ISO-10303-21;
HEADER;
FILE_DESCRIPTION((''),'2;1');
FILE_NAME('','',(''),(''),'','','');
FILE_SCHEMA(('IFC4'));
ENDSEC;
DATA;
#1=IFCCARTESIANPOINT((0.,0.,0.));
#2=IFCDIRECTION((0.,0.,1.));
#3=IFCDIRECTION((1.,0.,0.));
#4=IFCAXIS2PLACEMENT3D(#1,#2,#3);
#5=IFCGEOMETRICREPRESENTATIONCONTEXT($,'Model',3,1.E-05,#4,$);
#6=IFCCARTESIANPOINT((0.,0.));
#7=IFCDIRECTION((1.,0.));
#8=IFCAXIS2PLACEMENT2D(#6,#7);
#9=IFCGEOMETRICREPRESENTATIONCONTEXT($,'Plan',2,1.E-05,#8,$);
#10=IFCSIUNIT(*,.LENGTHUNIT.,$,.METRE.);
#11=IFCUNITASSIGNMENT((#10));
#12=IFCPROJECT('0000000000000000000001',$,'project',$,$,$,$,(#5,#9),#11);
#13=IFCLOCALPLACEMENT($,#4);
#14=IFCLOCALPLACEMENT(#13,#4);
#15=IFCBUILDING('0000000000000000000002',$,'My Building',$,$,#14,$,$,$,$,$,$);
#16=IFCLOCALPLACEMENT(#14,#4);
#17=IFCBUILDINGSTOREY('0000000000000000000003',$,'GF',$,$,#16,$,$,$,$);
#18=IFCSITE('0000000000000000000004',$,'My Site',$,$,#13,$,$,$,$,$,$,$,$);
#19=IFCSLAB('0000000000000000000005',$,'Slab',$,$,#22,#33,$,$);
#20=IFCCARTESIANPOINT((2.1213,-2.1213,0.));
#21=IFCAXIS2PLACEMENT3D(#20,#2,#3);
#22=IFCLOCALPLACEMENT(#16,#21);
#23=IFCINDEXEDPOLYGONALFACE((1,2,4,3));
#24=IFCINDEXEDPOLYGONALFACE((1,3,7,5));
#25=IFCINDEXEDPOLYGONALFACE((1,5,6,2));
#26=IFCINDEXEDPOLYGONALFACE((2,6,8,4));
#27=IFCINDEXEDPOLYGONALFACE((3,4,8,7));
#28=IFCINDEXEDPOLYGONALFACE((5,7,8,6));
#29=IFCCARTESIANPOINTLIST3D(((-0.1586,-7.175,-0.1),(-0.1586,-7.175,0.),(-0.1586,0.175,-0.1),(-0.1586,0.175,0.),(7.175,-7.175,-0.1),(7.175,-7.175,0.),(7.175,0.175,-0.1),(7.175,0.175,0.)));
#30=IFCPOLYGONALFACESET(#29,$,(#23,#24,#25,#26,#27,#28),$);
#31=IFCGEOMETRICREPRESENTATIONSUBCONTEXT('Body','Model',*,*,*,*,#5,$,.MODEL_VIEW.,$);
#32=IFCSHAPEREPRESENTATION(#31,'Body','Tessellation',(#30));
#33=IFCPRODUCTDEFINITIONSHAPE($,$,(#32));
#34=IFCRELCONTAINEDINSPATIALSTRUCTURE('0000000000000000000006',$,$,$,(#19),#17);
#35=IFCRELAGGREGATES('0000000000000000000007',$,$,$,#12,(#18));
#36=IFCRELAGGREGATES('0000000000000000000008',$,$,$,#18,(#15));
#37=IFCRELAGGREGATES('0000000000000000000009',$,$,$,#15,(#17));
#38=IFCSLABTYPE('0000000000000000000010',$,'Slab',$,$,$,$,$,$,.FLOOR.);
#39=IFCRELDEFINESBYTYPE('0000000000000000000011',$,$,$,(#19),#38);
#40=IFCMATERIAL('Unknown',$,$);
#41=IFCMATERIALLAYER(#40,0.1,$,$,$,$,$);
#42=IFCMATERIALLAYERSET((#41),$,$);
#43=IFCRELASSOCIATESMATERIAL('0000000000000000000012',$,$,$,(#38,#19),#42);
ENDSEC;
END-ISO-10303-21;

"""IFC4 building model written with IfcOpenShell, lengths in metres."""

from ifc_helpers import new_model, si_unit, frame, origin_with_axes, origin_2d_with_axis, place, context, subcontext, project, spatial, indexed_curve, outline, extrude, material, layer, layer_set, layer_usage, type_object, element, save


model = new_model("IFC4")

# Units and contexts
model_context = context("Model", 3, precision=1e-05, world=origin_with_axes())
plan_context = context("Plan", 2, precision=1e-05, world=origin_2d_with_axis())
body_context_1 = subcontext(model_context, "Body", "Model", "MODEL_VIEW")
ifc_project = project(units=[si_unit("LENGTHUNIT", "METRE")], contexts=[model_context, plan_context])

# Site, building, storey
site_placement = place(None, origin_with_axes())
site = spatial("IfcSite", under=ifc_project, at=site_placement, Name="My Site")
building_placement = place(site_placement, origin_with_axes())
building = spatial("IfcBuilding", under=site, at=building_placement, Name="My Building")
storey_placement = place(building_placement, origin_with_axes())
storey = spatial("IfcBuildingStorey", under=building, at=storey_placement, Name="GF")

# Shared definitions
ifc_material = material(Name="Unknown")

# Slab
ifc_layer_1 = layer(ifc_material, 0.1)
ifc_layer_set_1 = layer_set([ifc_layer_1])
ifc_layer_usage_1 = layer_usage(ifc_layer_set_1, "AXIS3", "POSITIVE", -0.1)
slab_type = type_object("IfcSlabType", Name="Slab", PredefinedType="FLOOR", material=ifc_layer_set_1)
slab_1_placement = place(storey_placement, frame((2.1213, -2.1213, 0.0), z_axis=(0.0, 0.0, 1.0), x_axis=(1.0, 0.0, 0.0)))
element("IfcSlab", 1, at=slab_1_placement, inside=storey, type_object=slab_type, material=ifc_layer_usage_1, Name="Slab", context=body_context_1, shape_type="SweptSolid", body=[
    extrude(outline(indexed_curve([(-0.1586, 0.175), (7.175, 0.175), (7.175, -7.175), (-0.1586, -7.175), (-0.1586, 0.175)])), frame((0.0, 0.0, -0.1), z_axis=(0.0, 0.0, 1.0), x_axis=(1.0, 0.0, 0.0)), (0.0, 0.0, 1.0), 0.1),
])

save(model, "model.ifc")
